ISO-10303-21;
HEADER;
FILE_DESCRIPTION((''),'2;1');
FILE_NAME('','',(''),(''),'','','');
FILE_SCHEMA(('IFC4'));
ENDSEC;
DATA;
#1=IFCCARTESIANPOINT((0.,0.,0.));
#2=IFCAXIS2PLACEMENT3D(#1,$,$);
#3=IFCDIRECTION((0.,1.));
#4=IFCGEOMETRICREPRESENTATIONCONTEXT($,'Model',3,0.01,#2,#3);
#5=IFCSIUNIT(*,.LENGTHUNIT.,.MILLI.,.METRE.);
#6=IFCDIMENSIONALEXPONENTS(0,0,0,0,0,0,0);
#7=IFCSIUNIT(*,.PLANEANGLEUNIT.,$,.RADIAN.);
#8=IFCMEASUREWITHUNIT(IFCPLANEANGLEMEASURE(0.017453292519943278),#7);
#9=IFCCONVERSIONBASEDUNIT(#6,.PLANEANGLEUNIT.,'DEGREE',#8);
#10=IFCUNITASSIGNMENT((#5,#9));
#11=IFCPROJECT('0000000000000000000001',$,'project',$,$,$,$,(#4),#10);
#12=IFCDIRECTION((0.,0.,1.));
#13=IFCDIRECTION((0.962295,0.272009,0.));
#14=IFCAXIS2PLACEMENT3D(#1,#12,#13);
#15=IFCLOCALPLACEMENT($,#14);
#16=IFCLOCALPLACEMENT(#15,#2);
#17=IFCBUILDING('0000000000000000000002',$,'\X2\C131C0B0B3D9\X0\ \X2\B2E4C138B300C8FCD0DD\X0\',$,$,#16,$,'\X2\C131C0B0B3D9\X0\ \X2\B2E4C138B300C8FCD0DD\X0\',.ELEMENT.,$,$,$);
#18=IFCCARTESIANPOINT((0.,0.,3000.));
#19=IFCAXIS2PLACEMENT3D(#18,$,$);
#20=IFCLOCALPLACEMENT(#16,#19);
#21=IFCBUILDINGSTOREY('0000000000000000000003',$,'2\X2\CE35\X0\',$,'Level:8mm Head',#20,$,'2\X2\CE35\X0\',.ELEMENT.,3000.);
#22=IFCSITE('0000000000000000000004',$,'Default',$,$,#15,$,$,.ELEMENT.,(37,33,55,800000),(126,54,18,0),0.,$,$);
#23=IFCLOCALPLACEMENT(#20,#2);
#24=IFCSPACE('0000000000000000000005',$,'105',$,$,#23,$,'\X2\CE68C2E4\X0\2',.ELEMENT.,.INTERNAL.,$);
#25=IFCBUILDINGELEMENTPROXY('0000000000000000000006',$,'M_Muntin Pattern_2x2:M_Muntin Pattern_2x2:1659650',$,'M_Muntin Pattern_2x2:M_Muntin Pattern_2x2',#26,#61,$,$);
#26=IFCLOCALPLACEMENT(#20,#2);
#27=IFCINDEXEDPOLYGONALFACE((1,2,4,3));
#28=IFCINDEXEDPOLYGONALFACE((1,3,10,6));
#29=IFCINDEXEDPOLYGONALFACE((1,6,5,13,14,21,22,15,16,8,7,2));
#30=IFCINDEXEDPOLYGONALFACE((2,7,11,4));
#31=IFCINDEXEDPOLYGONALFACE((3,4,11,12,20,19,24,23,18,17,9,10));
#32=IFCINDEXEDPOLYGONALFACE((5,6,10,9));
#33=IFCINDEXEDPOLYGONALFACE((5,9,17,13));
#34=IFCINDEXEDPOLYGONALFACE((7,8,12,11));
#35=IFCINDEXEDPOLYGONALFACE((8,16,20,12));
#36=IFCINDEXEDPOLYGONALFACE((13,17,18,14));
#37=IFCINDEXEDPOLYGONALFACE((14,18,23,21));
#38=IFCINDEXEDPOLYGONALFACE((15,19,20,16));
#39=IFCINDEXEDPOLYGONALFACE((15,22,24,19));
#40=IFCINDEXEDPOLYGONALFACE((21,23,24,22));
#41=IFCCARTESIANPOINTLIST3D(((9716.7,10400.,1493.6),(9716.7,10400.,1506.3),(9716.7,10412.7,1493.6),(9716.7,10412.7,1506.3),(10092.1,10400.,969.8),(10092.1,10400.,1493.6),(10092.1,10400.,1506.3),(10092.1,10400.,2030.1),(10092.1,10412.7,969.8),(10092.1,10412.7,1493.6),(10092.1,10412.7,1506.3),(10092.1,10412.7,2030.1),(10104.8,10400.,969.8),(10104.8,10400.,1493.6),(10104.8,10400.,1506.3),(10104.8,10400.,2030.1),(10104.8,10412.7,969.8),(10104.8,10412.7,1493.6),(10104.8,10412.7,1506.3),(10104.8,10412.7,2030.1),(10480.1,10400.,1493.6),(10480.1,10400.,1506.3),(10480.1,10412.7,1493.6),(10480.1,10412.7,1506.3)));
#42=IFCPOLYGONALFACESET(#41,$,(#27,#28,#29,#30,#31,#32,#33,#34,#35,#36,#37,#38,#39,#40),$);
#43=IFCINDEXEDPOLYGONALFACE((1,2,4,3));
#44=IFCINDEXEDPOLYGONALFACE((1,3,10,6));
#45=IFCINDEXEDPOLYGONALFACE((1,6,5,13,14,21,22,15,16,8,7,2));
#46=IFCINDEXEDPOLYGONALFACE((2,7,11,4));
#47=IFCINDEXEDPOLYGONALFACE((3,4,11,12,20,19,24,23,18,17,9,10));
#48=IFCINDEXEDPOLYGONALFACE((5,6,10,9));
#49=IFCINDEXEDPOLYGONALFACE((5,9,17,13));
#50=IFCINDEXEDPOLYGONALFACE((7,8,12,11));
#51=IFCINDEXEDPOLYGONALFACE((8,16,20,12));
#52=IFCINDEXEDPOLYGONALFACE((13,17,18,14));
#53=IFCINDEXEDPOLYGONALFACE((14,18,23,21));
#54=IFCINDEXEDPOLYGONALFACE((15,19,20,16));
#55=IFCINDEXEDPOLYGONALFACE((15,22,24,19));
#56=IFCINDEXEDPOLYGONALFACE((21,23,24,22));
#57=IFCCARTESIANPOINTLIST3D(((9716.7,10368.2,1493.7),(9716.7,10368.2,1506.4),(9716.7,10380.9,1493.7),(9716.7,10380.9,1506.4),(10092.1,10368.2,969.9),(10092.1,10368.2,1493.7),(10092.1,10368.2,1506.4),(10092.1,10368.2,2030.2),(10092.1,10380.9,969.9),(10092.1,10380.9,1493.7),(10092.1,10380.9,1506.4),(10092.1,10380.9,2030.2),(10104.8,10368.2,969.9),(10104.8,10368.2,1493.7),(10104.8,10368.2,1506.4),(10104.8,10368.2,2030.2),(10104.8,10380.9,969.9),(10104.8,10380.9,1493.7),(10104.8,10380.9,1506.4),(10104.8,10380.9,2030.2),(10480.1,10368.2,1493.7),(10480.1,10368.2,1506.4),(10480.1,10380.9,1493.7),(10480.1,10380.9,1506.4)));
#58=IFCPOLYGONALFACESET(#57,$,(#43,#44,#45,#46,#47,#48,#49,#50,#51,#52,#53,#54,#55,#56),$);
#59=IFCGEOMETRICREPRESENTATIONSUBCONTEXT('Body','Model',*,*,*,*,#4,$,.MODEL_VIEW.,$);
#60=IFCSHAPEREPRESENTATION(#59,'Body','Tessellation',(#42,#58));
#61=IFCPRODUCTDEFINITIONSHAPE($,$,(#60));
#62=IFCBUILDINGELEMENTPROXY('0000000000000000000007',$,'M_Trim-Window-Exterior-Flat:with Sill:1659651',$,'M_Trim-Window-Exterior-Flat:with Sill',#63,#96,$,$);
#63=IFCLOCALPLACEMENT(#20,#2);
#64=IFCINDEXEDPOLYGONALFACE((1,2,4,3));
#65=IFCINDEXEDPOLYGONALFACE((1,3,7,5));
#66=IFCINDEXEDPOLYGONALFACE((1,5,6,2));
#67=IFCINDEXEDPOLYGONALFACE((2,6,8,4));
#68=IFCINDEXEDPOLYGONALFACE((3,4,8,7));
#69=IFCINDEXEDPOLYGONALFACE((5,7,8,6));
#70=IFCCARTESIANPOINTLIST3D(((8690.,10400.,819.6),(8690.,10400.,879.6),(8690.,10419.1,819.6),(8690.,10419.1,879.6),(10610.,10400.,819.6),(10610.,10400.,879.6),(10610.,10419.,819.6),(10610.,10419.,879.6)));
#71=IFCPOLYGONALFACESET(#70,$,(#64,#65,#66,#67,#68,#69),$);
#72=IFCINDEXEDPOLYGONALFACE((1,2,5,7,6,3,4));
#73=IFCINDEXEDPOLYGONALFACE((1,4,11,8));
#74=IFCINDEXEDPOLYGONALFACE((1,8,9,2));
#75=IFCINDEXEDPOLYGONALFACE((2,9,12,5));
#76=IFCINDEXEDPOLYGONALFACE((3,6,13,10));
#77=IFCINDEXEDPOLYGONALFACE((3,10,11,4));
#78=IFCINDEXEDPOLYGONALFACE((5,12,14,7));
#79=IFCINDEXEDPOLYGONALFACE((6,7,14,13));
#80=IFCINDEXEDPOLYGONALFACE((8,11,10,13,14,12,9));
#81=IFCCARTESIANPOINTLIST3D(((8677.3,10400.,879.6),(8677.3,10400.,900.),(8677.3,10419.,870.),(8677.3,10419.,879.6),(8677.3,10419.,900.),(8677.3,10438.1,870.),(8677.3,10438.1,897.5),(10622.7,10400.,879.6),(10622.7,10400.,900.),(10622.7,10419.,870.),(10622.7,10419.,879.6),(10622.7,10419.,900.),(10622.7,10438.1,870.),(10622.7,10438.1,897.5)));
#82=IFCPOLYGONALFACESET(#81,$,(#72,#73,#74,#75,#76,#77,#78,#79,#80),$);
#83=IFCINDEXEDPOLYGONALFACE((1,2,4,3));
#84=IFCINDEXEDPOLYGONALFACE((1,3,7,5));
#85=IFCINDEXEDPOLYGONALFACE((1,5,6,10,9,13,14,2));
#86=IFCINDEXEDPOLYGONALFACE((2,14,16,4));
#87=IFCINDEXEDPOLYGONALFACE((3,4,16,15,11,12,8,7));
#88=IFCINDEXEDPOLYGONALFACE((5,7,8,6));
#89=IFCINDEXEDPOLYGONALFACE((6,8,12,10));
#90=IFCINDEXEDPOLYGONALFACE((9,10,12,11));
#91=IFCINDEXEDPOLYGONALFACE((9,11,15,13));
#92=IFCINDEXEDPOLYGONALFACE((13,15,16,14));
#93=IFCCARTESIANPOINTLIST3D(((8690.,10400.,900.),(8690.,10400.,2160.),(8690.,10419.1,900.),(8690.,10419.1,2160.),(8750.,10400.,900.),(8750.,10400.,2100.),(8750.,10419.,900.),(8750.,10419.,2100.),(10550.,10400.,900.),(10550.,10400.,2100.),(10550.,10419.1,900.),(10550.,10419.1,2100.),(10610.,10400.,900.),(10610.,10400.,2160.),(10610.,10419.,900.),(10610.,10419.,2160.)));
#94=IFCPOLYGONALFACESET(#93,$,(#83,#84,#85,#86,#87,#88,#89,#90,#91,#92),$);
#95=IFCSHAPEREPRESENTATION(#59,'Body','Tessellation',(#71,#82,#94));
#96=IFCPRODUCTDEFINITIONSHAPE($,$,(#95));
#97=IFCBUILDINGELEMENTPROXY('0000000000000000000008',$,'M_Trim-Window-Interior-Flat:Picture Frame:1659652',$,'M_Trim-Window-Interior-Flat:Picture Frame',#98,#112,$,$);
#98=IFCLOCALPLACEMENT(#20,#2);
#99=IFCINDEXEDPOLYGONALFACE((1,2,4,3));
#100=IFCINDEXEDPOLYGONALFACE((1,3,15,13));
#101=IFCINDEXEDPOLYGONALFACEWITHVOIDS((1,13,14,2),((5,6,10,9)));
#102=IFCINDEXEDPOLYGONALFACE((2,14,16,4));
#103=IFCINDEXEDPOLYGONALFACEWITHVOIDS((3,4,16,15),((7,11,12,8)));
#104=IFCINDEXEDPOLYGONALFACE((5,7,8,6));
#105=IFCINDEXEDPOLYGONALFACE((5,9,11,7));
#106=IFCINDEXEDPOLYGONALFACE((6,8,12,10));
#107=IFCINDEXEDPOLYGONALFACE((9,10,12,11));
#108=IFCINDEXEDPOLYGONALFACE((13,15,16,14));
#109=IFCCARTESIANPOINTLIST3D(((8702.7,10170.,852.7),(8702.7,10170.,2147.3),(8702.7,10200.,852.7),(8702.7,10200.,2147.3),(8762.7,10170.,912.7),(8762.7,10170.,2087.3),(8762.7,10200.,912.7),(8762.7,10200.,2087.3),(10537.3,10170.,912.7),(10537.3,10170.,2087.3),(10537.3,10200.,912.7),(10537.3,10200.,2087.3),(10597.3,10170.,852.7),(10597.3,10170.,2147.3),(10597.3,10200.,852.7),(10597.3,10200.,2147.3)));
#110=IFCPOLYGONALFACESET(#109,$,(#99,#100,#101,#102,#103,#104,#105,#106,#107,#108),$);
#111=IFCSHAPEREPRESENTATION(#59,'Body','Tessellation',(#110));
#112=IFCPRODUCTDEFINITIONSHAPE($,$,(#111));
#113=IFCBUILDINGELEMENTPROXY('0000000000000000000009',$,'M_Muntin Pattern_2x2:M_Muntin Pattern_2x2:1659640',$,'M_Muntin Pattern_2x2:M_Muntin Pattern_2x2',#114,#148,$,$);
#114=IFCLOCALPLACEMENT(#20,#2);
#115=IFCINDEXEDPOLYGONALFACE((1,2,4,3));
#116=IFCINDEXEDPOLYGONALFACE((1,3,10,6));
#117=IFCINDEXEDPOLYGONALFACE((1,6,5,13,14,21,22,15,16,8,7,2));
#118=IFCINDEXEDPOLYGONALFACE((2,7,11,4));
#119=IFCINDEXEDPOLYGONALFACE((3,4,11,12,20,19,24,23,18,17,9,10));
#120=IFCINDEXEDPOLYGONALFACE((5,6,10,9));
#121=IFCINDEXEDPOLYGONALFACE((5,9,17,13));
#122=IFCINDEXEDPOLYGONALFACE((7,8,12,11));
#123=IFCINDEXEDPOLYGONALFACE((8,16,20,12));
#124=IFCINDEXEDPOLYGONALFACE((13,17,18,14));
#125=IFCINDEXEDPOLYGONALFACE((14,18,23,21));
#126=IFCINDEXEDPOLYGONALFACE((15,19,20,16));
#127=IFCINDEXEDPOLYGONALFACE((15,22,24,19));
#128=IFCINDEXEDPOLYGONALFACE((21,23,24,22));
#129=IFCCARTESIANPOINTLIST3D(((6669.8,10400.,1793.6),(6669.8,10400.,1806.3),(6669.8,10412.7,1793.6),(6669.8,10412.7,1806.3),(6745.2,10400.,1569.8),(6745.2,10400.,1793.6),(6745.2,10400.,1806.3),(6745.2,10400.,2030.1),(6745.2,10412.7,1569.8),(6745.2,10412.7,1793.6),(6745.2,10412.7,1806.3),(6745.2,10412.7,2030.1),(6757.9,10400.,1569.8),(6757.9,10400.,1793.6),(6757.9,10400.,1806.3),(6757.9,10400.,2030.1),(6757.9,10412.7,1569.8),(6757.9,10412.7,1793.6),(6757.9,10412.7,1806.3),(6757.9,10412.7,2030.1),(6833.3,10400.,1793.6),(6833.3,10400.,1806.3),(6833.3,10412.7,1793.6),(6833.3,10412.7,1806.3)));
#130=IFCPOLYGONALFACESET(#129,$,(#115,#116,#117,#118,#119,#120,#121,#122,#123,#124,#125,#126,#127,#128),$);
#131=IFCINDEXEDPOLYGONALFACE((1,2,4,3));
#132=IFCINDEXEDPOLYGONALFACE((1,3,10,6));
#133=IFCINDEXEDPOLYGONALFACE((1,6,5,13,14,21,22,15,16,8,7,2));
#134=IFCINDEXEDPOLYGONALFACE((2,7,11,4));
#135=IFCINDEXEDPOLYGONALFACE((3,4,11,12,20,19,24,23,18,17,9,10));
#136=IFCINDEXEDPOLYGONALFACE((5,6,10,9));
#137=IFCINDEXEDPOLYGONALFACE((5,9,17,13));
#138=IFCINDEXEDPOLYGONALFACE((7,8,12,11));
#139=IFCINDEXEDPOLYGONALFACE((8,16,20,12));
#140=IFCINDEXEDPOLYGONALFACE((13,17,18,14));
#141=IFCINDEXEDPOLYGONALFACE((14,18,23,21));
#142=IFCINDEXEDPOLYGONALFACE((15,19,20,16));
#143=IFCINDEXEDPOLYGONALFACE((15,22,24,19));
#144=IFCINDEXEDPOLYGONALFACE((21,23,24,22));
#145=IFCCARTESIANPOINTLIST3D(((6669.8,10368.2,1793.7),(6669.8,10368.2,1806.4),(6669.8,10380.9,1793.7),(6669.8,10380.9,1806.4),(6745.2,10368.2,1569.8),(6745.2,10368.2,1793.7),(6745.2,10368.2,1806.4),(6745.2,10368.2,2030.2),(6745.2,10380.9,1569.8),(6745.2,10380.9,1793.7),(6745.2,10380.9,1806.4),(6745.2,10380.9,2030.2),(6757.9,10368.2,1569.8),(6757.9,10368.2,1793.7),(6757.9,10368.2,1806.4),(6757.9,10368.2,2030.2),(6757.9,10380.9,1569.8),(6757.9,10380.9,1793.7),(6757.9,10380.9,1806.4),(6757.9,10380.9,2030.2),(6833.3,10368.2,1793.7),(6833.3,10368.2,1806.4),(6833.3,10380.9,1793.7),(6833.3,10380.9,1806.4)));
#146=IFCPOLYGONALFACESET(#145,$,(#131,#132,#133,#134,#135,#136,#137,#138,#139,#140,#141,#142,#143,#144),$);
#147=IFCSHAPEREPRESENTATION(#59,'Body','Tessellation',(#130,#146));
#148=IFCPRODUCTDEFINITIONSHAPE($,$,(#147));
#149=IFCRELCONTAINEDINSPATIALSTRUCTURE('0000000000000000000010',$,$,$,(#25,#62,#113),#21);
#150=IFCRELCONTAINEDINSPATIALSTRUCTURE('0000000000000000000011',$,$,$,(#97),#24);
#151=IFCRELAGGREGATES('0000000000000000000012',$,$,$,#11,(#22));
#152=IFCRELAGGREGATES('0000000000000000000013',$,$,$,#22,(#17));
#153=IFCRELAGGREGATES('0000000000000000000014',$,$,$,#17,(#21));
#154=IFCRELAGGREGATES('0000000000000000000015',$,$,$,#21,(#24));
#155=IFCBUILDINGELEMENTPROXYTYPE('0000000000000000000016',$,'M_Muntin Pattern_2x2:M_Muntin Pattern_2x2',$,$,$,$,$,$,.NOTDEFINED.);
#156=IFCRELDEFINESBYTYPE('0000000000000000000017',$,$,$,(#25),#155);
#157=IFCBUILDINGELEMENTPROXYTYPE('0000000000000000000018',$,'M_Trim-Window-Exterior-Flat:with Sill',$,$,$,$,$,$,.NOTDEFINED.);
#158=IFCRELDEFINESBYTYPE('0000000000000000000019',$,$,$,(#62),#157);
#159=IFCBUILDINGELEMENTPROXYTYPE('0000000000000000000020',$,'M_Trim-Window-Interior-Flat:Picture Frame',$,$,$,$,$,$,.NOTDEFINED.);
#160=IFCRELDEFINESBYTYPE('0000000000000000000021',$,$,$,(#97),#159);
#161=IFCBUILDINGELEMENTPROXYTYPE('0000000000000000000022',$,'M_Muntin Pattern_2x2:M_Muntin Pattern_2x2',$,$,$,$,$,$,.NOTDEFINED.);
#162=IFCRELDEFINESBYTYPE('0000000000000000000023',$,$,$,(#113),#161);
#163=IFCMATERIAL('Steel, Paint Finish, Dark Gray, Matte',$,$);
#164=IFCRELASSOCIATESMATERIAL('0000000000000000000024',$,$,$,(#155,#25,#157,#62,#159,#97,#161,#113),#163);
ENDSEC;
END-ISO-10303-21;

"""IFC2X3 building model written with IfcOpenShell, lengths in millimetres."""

from ifc_helpers import new_model, entity, si_unit, converted_unit, direction, frame, frame_2d, origin, place, context, subcontext, project, spatial, polyline, rectangle, outline, extrude, source, transform, mapped, material, type_object, type_shapes, element, save


model = new_model("IFC2X3")

# Units and contexts
model_context = context("Model", 3, precision=0.01, world=origin(), true_north=direction((0.0, 1.0)))
body_context = subcontext(model_context, "Body", "Model", "MODEL_VIEW")
ifc_project = project(units=[si_unit("LENGTHUNIT", "METRE", prefix="MILLI"), converted_unit("PLANEANGLEUNIT", "DEGREE", entity("IfcPlaneAngleMeasure", 0.017453292519943278), si_unit("PLANEANGLEUNIT", "RADIAN"), dimensions=[0, 0, 0, 0, 0, 0, 0])], contexts=[model_context])

# Site, building, storey
site_placement = place(None, frame((0.0, 0.0, 0.0), z_axis=(0.0, 0.0, 1.0), x_axis=(0.962295, 0.272009, 0.0)))
site = spatial("IfcSite", under=ifc_project, at=site_placement, Name="Default", CompositionType="ELEMENT", RefLatitude=(37, 33, 55, 800000), RefLongitude=(126, 54, 18, 0), RefElevation=0.0)
building_placement = place(site_placement, origin())
building = spatial("IfcBuilding", under=site, at=building_placement, Name="성산동 다세대주택", LongName="성산동 다세대주택", CompositionType="ELEMENT")
storey_placement = place(building_placement, frame((0.0, 0.0, 3000.0)))
storey = spatial("IfcBuildingStorey", under=building, at=storey_placement, Name="2층", ObjectType="Level:8mm Head", LongName="2층", CompositionType="ELEMENT", Elevation=3000.0)

# Shared definitions
space_1_placement = place(storey_placement, origin())
space_1 = spatial("IfcSpace", under=storey, at=space_1_placement, Name="105", LongName="침실2", CompositionType="ELEMENT", InteriorOrExteriorSpace="INTERNAL")

# Building element proxies
ifc_material_1 = material(Name="Steel, Paint Finish, Dark Gray, Matte")
building_element_proxy_type_1 = type_object("IfcBuildingElementProxyType", Name="M_Muntin Pattern_2x2:M_Muntin Pattern_2x2", PredefinedType="NOTDEFINED", material=ifc_material_1)
shared_shape_1 = source(origin(), body_context, "Body", "SweptSolid", [
    extrude(outline(polyline([(6.4, -6.4), (530.1, -6.4), (530.1, 6.3), (6.4, 6.3), (6.4, 381.7), (-6.3, 381.7), (-6.3, 6.3), (-530.2, 6.3), (-530.2, -6.4), (-6.3, -6.4), (-6.3, -381.7), (6.4, -381.7), (6.4, -6.4)])), frame((0.0, -22.2, 530.1), z_axis=(0.0, 1.0, 0.0), x_axis=(0.0, 0.0, 1.0)), (0.0, 0.0, 1.0), 12.7),
    extrude(outline(polyline([(6.4, -6.4), (530.2, -6.4), (530.2, 6.3), (6.4, 6.3), (6.4, 381.7), (-6.3, 381.7), (-6.3, 6.3), (-530.2, 6.3), (-530.2, -6.4), (-6.3, -6.4), (-6.3, -381.7), (6.4, -381.7), (6.4, -6.4)])), frame((0.0, 9.5, 530.2), z_axis=(0.0, 1.0, 0.0), x_axis=(0.0, 0.0, 1.0)), (0.0, 0.0, 1.0), 12.7),
])
type_shapes(building_element_proxy_type_1, [shared_shape_1])
proxy_1_placement = place(storey_placement, frame((10098.4, 10390.5, 969.9), z_axis=(0.0, 0.0, 1.0), x_axis=(-1.0, 0.0, 0.0)))
element("IfcBuildingElementProxy", 1, at=proxy_1_placement, inside=storey, type_object=building_element_proxy_type_1, material=ifc_material_1, Name="M_Muntin Pattern_2x2:M_Muntin Pattern_2x2:1659650", ObjectType="M_Muntin Pattern_2x2:M_Muntin Pattern_2x2", context=body_context, shape_type="MappedRepresentation", body=[
    mapped(shared_shape_1, transform((0.0, 0.0, 0.0), scale=1.0)),
])
building_element_proxy_type_2 = type_object("IfcBuildingElementProxyType", Name="M_Trim-Window-Exterior-Flat:with Sill", PredefinedType="NOTDEFINED", material=ifc_material_1)
shared_shape_2 = source(origin(), body_context, "Body", "SweptSolid", [
    extrude(rectangle(XDim=1920.0, YDim=60.0, at=frame_2d((0.0, 0.0), x_axis=(1.0, 0.0))), frame((0.0, -1250.4, 0.0), z_axis=(0.0, 0.0, 1.0), x_axis=(-1.0, 0.0, 0.0)), (0.0, 0.0, 1.0), 19.0),
    extrude(outline(polyline([(-19.0, -15.2), (0.0, -15.2), (0.0, -5.7), (19.0, -5.7), (19.0, 14.8), (0.0, 14.8), (-19.0, 12.3), (-19.0, -15.2)])), frame((-972.7, -1214.8, 19.0), z_axis=(1.0, 0.0, 0.0), x_axis=(0.0, 0.0, -1.0)), (0.0, 0.0, 1.0), 1945.4),
    extrude(outline(polyline([(-645.0, -960.0), (615.0, -960.0), (615.0, -900.0), (-585.0, -900.0), (-585.0, 900.0), (615.0, 900.0), (615.0, 960.0), (-645.0, 960.0), (-645.0, -960.0)])), frame((0.0, -585.0, 0.0), z_axis=(0.0, 0.0, 1.0), x_axis=(0.0, -1.0, 0.0)), (0.0, 0.0, 1.0), 19.0),
])
type_shapes(building_element_proxy_type_2, [shared_shape_2])
proxy_2_placement = place(storey_placement, frame((9650.0, 10400.0, 2100.0), z_axis=(0.0, 1.0, 0.0), x_axis=(-1.0, 0.0, 0.0)))
element("IfcBuildingElementProxy", 2, at=proxy_2_placement, inside=storey, type_object=building_element_proxy_type_2, material=ifc_material_1, Name="M_Trim-Window-Exterior-Flat:with Sill:1659651", ObjectType="M_Trim-Window-Exterior-Flat:with Sill", context=body_context, shape_type="MappedRepresentation", body=[
    mapped(shared_shape_2, transform((0.0, 0.0, 0.0), scale=1.0)),
])
building_element_proxy_type_3 = type_object("IfcBuildingElementProxyType", Name="M_Trim-Window-Interior-Flat:Picture Frame", PredefinedType="NOTDEFINED", material=ifc_material_1)
shared_shape_3 = source(origin(), body_context, "Body", "SweptSolid", [
    extrude(outline(polyline([(-947.3, -647.3), (947.3, -647.3), (947.3, 647.3), (-947.3, 647.3), (-947.3, -647.3)]), holes=[polyline([(-887.3, -587.3), (-887.3, 587.3), (887.3, 587.3), (887.3, -587.3), (-887.3, -587.3)])]), frame((0.0, -600.0, 0.0), z_axis=(0.0, 0.0, 1.0), x_axis=(-1.0, 0.0, 0.0)), (0.0, 0.0, 1.0), 30.0),
])
type_shapes(building_element_proxy_type_3, [shared_shape_3])
proxy_3_placement = place(space_1_placement, frame((9650.0, 10200.0, 2100.0), z_axis=(0.0, -1.0, 0.0), x_axis=(1.0, 0.0, 0.0)))
element("IfcBuildingElementProxy", 3, at=proxy_3_placement, inside=space_1, type_object=building_element_proxy_type_3, material=ifc_material_1, Name="M_Trim-Window-Interior-Flat:Picture Frame:1659652", ObjectType="M_Trim-Window-Interior-Flat:Picture Frame", context=body_context, shape_type="MappedRepresentation", body=[
    mapped(shared_shape_3, transform((0.0, 0.0, 0.0), scale=1.0)),
])
building_element_proxy_type_4 = type_object("IfcBuildingElementProxyType", Name="M_Muntin Pattern_2x2:M_Muntin Pattern_2x2", PredefinedType="NOTDEFINED", material=ifc_material_1)
shared_shape_4 = source(origin(), body_context, "Body", "SweptSolid", [
    extrude(outline(polyline([(6.4, -6.4), (230.1, -6.4), (230.1, 6.3), (6.4, 6.3), (6.4, 81.7), (-6.3, 81.7), (-6.3, 6.3), (-230.2, 6.3), (-230.2, -6.4), (-6.3, -6.4), (-6.3, -81.7), (6.4, -81.7), (6.4, -6.4)])), frame((0.0, 9.5, 230.1), z_axis=(0.0, 1.0, 0.0), x_axis=(0.0, 0.0, 1.0)), (0.0, 0.0, 1.0), 12.7),
    extrude(outline(polyline([(6.4, -6.4), (230.2, -6.4), (230.2, 6.3), (6.4, 6.3), (6.4, 81.7), (-6.3, 81.7), (-6.3, 6.3), (-230.2, 6.3), (-230.2, -6.4), (-6.3, -6.4), (-6.3, -81.7), (6.4, -81.7), (6.4, -6.4)])), frame((0.0, -22.2, 230.2), z_axis=(0.0, 1.0, 0.0), x_axis=(0.0, 0.0, 1.0)), (0.0, 0.0, 1.0), 12.7),
])
type_shapes(building_element_proxy_type_4, [shared_shape_4])
proxy_4_placement = place(storey_placement, frame((6751.6, 10390.5, 1569.8)))
element("IfcBuildingElementProxy", 4, at=proxy_4_placement, inside=storey, type_object=building_element_proxy_type_4, material=ifc_material_1, Name="M_Muntin Pattern_2x2:M_Muntin Pattern_2x2:1659640", ObjectType="M_Muntin Pattern_2x2:M_Muntin Pattern_2x2", context=body_context, shape_type="MappedRepresentation", body=[
    mapped(shared_shape_4, transform((0.0, 0.0, 0.0), scale=1.0)),
])

save(model, "model.ifc")
